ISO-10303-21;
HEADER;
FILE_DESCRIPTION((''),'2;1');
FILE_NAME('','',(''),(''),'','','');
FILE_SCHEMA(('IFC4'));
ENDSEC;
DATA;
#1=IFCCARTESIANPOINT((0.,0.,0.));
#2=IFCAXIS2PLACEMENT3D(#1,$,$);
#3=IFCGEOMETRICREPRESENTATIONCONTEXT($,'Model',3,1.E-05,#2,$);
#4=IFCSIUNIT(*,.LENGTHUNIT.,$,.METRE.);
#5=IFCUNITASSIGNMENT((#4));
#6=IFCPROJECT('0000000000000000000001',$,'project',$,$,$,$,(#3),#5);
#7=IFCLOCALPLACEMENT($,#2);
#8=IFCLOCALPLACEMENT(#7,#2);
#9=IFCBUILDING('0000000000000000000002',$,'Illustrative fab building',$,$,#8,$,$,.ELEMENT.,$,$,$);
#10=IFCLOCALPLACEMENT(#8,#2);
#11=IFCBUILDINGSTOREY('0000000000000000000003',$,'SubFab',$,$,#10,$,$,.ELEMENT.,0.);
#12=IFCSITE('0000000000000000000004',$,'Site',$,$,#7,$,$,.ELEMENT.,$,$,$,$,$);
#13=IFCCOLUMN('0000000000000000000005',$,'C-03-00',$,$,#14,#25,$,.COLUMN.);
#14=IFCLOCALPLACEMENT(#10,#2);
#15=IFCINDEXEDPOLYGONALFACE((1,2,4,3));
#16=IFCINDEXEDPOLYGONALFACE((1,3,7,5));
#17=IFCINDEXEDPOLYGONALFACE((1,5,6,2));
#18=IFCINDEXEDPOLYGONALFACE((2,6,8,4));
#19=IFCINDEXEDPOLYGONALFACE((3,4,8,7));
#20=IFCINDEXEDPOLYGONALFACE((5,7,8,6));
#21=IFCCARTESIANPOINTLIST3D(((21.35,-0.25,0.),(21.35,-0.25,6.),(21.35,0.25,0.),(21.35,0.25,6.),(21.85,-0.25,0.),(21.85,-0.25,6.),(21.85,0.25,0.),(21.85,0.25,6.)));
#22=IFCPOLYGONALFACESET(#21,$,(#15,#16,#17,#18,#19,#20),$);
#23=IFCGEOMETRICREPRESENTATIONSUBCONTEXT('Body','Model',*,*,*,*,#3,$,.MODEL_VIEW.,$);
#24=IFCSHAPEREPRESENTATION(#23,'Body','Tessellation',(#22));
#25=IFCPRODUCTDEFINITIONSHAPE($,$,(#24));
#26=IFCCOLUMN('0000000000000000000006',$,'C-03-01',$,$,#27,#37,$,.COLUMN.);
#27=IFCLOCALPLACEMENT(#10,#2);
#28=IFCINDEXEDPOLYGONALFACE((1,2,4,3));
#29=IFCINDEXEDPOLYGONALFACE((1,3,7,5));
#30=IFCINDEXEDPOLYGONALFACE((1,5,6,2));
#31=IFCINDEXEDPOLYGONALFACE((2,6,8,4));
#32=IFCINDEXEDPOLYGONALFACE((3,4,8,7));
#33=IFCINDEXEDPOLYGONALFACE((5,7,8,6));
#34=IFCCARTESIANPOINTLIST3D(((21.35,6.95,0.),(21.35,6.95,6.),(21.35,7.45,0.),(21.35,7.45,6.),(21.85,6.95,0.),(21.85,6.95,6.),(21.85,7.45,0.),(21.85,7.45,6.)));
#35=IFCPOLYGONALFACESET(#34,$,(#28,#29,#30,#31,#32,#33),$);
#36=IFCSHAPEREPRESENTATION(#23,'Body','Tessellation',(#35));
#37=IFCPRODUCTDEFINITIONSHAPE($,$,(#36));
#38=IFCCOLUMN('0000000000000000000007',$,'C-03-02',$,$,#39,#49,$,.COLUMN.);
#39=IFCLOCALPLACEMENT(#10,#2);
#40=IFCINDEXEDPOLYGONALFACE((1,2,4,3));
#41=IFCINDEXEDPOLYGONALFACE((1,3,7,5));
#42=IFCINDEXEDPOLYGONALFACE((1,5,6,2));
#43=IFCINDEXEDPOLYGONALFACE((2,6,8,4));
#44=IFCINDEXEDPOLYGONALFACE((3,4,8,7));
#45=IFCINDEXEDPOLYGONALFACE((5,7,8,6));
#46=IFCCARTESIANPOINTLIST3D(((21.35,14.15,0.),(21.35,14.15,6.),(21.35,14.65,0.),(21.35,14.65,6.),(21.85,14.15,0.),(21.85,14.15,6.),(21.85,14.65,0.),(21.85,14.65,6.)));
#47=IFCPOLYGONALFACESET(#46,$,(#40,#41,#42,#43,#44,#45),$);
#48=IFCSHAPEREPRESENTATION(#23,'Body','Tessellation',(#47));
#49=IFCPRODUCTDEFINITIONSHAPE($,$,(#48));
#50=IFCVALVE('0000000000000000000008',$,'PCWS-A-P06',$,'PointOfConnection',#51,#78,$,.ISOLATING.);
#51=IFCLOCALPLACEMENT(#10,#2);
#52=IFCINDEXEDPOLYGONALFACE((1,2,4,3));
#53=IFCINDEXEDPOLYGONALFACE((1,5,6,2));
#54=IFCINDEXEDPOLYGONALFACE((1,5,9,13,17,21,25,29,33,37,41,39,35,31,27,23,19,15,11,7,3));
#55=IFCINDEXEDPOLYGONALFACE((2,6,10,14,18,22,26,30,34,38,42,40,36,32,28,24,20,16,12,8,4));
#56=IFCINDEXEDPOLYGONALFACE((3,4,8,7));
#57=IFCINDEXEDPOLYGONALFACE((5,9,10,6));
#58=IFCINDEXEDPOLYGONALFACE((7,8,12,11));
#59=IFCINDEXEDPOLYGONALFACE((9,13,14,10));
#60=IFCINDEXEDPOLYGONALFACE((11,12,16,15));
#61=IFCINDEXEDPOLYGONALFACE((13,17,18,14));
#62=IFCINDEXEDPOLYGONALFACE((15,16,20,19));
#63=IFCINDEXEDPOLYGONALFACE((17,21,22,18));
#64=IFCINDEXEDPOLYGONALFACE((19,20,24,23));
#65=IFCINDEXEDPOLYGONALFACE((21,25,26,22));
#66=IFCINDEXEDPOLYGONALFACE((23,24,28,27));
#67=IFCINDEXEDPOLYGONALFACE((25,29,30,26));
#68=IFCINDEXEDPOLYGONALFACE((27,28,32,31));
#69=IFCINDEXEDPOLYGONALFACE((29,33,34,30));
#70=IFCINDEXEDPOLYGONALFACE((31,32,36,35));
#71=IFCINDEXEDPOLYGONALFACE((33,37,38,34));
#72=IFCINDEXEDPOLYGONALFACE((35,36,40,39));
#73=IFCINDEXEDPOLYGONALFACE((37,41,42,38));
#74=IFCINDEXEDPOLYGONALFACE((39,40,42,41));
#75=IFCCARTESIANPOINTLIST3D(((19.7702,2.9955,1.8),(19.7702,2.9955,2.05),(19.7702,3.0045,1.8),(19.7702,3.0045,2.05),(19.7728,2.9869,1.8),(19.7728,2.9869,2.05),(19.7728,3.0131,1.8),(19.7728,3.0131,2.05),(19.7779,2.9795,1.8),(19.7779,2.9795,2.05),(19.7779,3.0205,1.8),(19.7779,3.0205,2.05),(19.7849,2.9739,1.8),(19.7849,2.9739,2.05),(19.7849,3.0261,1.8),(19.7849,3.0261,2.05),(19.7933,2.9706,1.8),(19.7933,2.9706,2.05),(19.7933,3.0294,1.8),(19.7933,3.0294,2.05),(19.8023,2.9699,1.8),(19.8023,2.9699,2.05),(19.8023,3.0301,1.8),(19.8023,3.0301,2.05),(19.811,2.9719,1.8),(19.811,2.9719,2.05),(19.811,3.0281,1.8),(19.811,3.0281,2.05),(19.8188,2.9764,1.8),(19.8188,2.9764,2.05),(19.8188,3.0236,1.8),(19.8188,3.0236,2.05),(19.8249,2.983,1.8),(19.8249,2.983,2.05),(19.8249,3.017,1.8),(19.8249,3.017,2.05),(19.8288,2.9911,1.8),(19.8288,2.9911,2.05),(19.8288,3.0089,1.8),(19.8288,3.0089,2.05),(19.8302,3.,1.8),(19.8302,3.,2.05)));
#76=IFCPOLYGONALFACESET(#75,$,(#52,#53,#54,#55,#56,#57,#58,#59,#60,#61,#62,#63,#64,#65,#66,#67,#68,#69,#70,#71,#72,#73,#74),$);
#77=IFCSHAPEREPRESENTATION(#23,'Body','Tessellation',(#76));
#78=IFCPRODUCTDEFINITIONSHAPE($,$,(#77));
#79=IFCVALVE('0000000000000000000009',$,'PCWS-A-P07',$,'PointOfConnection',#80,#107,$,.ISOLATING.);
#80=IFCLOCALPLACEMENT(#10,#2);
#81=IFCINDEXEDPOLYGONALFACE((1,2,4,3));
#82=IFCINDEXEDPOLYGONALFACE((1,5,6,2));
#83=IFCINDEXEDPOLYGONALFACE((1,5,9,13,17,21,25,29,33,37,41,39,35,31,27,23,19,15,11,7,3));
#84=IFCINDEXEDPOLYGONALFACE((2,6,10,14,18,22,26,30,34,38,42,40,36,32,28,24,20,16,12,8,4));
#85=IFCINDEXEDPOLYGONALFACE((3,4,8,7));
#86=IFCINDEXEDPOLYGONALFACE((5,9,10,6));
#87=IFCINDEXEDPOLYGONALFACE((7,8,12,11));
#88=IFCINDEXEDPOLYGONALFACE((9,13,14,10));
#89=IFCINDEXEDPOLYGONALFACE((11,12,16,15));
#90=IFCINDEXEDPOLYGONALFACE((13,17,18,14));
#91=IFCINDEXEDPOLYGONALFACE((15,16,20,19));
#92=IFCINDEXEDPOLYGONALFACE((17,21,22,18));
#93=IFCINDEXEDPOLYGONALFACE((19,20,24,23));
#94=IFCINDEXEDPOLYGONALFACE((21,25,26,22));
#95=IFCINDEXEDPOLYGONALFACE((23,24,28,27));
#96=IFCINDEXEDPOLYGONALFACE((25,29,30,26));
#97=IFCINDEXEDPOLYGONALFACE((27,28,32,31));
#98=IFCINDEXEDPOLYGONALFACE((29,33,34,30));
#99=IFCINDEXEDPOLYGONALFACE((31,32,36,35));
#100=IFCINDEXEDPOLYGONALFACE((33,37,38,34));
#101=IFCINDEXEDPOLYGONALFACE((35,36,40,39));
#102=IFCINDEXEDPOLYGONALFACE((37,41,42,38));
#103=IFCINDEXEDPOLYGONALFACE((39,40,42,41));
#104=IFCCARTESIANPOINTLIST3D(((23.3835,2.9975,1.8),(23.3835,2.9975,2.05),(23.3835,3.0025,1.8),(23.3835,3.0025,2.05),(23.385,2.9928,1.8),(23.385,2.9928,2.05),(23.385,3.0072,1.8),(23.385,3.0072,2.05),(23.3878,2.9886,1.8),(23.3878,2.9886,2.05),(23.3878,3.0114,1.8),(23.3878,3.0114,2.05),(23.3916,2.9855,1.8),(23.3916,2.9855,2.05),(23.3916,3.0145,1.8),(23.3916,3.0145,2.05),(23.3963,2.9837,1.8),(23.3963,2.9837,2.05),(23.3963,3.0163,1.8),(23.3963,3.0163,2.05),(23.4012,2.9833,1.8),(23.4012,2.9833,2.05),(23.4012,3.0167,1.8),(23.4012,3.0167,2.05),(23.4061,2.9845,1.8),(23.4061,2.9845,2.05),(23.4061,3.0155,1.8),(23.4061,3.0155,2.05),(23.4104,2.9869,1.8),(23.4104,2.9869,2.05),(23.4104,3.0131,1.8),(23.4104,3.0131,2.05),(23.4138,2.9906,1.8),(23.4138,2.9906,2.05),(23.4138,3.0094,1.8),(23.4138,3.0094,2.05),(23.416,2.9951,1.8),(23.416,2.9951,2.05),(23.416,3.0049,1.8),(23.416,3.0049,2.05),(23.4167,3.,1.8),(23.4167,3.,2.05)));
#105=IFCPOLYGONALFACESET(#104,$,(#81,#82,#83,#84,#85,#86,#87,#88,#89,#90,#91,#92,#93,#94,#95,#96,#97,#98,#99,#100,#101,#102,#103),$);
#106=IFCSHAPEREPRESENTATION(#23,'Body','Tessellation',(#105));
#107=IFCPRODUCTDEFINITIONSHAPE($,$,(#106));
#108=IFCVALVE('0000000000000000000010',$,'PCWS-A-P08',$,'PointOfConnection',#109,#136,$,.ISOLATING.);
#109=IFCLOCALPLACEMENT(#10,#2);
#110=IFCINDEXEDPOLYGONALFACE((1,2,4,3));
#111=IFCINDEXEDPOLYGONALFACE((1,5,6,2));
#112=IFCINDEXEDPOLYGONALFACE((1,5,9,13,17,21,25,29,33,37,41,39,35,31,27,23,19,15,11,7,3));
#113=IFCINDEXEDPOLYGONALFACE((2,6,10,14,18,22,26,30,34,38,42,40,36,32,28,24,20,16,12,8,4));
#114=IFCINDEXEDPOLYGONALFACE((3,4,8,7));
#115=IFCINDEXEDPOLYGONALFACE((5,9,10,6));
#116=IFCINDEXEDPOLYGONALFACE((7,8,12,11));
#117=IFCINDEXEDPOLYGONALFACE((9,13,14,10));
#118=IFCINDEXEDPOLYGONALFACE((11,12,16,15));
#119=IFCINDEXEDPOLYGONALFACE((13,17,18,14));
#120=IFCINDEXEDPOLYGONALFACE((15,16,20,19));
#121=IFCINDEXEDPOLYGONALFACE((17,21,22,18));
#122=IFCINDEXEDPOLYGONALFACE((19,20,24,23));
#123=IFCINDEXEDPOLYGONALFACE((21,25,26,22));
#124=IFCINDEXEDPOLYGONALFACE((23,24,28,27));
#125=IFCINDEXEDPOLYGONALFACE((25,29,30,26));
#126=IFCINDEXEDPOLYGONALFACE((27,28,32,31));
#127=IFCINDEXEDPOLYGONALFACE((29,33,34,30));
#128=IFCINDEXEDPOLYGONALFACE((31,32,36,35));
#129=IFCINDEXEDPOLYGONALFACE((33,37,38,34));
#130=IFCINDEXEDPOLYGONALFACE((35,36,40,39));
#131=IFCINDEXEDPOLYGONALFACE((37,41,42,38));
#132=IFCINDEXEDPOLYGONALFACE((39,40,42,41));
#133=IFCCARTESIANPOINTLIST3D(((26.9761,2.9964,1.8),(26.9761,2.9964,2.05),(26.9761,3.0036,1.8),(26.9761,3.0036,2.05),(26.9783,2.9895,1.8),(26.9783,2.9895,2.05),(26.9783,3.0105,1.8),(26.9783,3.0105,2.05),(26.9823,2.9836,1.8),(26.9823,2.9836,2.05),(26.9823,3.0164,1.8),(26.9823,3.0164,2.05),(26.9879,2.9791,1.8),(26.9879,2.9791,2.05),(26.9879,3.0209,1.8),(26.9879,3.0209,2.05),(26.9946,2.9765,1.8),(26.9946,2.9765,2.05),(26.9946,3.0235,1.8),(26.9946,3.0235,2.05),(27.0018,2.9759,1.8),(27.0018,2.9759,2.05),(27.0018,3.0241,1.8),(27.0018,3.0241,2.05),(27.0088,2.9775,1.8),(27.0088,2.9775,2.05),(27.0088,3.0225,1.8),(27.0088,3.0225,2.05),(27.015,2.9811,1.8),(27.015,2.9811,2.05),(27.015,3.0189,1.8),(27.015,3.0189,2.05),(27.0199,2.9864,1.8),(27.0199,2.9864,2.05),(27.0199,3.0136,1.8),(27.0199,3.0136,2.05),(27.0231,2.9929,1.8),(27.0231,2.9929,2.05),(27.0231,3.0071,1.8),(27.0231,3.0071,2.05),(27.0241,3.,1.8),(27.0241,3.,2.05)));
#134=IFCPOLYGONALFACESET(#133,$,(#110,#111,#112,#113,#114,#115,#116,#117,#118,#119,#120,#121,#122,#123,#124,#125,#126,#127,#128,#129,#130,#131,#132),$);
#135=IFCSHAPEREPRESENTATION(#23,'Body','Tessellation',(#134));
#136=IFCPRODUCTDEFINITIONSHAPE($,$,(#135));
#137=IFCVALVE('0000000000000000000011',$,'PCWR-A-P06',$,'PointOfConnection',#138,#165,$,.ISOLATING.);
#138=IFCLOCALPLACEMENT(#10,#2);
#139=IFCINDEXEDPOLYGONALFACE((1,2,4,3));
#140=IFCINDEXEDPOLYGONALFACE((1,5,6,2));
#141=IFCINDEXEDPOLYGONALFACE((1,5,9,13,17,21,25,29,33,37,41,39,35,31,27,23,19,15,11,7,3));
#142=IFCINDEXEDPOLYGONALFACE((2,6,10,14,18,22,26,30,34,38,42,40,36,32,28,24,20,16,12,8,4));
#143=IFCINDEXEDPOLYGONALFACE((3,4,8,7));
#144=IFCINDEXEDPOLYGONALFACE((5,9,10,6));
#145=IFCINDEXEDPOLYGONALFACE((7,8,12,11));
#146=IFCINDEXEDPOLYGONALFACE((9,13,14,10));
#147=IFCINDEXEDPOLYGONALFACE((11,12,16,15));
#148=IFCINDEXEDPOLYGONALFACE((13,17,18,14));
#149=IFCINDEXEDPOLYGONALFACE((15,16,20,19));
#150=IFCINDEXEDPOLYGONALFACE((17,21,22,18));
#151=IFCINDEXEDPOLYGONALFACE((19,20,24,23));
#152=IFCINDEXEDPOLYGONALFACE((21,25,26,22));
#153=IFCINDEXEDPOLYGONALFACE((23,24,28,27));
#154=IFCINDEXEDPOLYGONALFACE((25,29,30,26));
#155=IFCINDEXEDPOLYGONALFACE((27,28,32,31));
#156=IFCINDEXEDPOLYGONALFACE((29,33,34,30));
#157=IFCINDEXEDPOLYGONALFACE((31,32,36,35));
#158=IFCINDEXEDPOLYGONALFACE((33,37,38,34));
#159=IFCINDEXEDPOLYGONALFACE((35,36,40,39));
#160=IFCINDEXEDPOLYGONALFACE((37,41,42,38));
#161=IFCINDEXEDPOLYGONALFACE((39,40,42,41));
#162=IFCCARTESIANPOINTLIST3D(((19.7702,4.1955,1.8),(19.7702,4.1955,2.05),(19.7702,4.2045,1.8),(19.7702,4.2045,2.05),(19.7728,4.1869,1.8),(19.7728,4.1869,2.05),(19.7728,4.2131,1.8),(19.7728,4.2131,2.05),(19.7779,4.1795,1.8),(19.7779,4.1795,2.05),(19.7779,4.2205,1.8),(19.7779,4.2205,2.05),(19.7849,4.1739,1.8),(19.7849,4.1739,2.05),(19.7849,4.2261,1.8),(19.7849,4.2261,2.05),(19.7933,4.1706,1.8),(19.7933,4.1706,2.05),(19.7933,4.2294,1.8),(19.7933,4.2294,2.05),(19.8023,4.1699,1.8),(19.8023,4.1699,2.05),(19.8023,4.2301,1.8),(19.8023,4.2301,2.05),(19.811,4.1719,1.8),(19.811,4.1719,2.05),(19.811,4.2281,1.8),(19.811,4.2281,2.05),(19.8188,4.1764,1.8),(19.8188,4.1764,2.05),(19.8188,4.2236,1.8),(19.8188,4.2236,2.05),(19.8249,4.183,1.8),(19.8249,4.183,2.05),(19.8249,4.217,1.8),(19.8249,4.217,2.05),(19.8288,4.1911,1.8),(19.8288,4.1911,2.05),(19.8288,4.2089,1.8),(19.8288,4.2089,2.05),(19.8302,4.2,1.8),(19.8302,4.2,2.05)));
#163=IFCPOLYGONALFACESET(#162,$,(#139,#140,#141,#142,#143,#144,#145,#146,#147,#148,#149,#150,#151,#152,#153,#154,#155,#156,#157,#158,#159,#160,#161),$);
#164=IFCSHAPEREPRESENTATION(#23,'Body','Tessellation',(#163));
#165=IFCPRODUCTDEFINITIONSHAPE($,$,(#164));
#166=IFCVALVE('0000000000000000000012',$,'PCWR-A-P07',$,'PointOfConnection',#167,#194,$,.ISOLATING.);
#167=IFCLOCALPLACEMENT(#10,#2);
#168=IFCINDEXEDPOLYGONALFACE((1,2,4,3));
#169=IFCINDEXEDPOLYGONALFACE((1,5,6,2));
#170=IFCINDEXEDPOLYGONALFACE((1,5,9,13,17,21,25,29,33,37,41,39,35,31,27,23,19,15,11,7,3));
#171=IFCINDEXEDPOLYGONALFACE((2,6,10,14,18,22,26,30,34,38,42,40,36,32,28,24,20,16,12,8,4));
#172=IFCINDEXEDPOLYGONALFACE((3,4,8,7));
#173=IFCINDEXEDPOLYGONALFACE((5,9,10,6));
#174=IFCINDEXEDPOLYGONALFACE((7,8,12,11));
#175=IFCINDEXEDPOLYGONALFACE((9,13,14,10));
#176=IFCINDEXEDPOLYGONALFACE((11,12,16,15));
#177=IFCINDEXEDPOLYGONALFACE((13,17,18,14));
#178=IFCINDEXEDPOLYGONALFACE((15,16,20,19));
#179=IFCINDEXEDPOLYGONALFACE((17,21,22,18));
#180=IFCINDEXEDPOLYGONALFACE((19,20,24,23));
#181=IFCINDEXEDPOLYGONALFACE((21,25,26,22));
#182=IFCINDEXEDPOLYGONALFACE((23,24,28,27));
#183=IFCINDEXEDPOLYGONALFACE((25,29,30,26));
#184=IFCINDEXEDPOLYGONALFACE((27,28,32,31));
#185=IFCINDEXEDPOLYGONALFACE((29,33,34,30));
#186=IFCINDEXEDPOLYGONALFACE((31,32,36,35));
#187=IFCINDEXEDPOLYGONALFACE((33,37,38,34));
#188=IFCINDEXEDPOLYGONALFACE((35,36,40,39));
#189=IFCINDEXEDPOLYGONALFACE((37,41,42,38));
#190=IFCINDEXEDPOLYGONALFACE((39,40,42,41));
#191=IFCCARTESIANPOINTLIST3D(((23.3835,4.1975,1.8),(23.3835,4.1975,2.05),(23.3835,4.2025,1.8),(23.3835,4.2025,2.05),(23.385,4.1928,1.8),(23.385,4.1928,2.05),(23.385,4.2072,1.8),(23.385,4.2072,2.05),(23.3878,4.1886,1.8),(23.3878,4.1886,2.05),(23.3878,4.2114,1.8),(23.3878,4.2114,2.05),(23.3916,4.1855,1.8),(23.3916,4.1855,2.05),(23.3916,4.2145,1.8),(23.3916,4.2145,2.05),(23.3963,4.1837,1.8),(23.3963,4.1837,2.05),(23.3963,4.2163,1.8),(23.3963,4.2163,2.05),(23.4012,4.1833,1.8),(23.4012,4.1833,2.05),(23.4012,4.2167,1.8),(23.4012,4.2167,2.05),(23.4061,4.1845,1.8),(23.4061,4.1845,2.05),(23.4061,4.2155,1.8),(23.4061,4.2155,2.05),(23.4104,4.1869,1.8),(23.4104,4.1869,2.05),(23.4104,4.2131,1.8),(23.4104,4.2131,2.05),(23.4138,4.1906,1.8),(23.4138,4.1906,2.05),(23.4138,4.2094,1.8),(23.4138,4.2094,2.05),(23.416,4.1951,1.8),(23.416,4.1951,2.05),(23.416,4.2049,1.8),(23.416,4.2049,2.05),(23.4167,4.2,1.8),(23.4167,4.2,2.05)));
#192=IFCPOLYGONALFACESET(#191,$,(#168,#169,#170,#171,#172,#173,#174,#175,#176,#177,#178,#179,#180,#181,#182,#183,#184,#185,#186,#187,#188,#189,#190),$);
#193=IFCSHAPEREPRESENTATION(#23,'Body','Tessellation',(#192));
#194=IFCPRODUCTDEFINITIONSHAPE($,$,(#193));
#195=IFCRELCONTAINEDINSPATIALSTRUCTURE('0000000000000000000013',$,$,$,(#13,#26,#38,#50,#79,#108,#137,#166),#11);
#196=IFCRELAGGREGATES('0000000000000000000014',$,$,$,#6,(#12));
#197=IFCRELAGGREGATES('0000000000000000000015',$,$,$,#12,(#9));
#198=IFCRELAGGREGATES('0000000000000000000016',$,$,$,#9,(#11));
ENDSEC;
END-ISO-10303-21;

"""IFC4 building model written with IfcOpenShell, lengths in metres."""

from ifc_helpers import new_model, entity, si_unit, frame, origin, origin_2d, place, context, subcontext, project, spatial, rectangle, extrude, element, save


model = new_model("IFC4")

# Units and contexts
model_context = context("Model", 3, precision=1e-05, world=origin())
body_context = subcontext(model_context, "Body", "Model", "MODEL_VIEW")
ifc_project = project(units=[si_unit("LENGTHUNIT", "METRE")], contexts=[model_context])

# Site, building, storey
site_placement = place(None, origin())
site = spatial("IfcSite", under=ifc_project, at=site_placement, Name="Site", CompositionType="ELEMENT")
building_placement = place(site_placement, origin())
building = spatial("IfcBuilding", under=site, at=building_placement, Name="Illustrative fab building", CompositionType="ELEMENT")
storey_placement = place(building_placement, origin())
storey = spatial("IfcBuildingStorey", under=building, at=storey_placement, Name="SubFab", CompositionType="ELEMENT", Elevation=0.0)

# Columns
for number, where, name in (
    (1, (21.6, 0.0, 0.0), "C-03-00"),
    (2, (21.6, 7.2, 0.0), "C-03-01"),
    (3, (21.6, 14.4, 0.0), "C-03-02"),
):
    element("IfcColumn", number, at=place(storey_placement, frame(where)), inside=storey, Name=name, PredefinedType="COLUMN", context=body_context, shape_type="SweptSolid", body=[
        extrude(rectangle(XDim=0.5, YDim=0.5, at=origin_2d()), origin(), (0.0, 0.0, 1.0), 6.0),
    ])

# Valves
valve_1_placement = place(storey_placement, frame((19.8, 3.0, 1.8)))
element("IfcValve", 4, at=valve_1_placement, inside=storey, Name="PCWS-A-P06", ObjectType="PointOfConnection", PredefinedType="ISOLATING", context=body_context, shape_type="AdvancedSweptSolid", body=[
    entity("IfcSweptDiskSolid", entity("IfcPolyline", [entity("IfcCartesianPoint", [0.0, 0.0, 0.0]), entity("IfcCartesianPoint", [0.0, 0.0, 0.25])]), 0.0302),
])
valve_2_placement = place(storey_placement, frame((23.4, 3.0, 1.8)))
element("IfcValve", 5, at=valve_2_placement, inside=storey, Name="PCWS-A-P07", ObjectType="PointOfConnection", PredefinedType="ISOLATING", context=body_context, shape_type="AdvancedSweptSolid", body=[
    entity("IfcSweptDiskSolid", entity("IfcPolyline", [entity("IfcCartesianPoint", [0.0, 0.0, 0.0]), entity("IfcCartesianPoint", [0.0, 0.0, 0.25])]), 0.0167),
])
valve_3_placement = place(storey_placement, frame((27.0, 3.0, 1.8)))
element("IfcValve", 6, at=valve_3_placement, inside=storey, Name="PCWS-A-P08", ObjectType="PointOfConnection", PredefinedType="ISOLATING", context=body_context, shape_type="AdvancedSweptSolid", body=[
    entity("IfcSweptDiskSolid", entity("IfcPolyline", [entity("IfcCartesianPoint", [0.0, 0.0, 0.0]), entity("IfcCartesianPoint", [0.0, 0.0, 0.25])]), 0.0241),
])
valve_4_placement = place(storey_placement, frame((19.8, 4.2, 1.8)))
element("IfcValve", 7, at=valve_4_placement, inside=storey, Name="PCWR-A-P06", ObjectType="PointOfConnection", PredefinedType="ISOLATING", context=body_context, shape_type="AdvancedSweptSolid", body=[
    entity("IfcSweptDiskSolid", entity("IfcPolyline", [entity("IfcCartesianPoint", [0.0, 0.0, 0.0]), entity("IfcCartesianPoint", [0.0, 0.0, 0.25])]), 0.0302),
])
valve_5_placement = place(storey_placement, frame((23.4, 4.2, 1.8)))
element("IfcValve", 8, at=valve_5_placement, inside=storey, Name="PCWR-A-P07", ObjectType="PointOfConnection", PredefinedType="ISOLATING", context=body_context, shape_type="AdvancedSweptSolid", body=[
    entity("IfcSweptDiskSolid", entity("IfcPolyline", [entity("IfcCartesianPoint", [0.0, 0.0, 0.0]), entity("IfcCartesianPoint", [0.0, 0.0, 0.25])]), 0.0167),
])

save(model, "model.ifc")
